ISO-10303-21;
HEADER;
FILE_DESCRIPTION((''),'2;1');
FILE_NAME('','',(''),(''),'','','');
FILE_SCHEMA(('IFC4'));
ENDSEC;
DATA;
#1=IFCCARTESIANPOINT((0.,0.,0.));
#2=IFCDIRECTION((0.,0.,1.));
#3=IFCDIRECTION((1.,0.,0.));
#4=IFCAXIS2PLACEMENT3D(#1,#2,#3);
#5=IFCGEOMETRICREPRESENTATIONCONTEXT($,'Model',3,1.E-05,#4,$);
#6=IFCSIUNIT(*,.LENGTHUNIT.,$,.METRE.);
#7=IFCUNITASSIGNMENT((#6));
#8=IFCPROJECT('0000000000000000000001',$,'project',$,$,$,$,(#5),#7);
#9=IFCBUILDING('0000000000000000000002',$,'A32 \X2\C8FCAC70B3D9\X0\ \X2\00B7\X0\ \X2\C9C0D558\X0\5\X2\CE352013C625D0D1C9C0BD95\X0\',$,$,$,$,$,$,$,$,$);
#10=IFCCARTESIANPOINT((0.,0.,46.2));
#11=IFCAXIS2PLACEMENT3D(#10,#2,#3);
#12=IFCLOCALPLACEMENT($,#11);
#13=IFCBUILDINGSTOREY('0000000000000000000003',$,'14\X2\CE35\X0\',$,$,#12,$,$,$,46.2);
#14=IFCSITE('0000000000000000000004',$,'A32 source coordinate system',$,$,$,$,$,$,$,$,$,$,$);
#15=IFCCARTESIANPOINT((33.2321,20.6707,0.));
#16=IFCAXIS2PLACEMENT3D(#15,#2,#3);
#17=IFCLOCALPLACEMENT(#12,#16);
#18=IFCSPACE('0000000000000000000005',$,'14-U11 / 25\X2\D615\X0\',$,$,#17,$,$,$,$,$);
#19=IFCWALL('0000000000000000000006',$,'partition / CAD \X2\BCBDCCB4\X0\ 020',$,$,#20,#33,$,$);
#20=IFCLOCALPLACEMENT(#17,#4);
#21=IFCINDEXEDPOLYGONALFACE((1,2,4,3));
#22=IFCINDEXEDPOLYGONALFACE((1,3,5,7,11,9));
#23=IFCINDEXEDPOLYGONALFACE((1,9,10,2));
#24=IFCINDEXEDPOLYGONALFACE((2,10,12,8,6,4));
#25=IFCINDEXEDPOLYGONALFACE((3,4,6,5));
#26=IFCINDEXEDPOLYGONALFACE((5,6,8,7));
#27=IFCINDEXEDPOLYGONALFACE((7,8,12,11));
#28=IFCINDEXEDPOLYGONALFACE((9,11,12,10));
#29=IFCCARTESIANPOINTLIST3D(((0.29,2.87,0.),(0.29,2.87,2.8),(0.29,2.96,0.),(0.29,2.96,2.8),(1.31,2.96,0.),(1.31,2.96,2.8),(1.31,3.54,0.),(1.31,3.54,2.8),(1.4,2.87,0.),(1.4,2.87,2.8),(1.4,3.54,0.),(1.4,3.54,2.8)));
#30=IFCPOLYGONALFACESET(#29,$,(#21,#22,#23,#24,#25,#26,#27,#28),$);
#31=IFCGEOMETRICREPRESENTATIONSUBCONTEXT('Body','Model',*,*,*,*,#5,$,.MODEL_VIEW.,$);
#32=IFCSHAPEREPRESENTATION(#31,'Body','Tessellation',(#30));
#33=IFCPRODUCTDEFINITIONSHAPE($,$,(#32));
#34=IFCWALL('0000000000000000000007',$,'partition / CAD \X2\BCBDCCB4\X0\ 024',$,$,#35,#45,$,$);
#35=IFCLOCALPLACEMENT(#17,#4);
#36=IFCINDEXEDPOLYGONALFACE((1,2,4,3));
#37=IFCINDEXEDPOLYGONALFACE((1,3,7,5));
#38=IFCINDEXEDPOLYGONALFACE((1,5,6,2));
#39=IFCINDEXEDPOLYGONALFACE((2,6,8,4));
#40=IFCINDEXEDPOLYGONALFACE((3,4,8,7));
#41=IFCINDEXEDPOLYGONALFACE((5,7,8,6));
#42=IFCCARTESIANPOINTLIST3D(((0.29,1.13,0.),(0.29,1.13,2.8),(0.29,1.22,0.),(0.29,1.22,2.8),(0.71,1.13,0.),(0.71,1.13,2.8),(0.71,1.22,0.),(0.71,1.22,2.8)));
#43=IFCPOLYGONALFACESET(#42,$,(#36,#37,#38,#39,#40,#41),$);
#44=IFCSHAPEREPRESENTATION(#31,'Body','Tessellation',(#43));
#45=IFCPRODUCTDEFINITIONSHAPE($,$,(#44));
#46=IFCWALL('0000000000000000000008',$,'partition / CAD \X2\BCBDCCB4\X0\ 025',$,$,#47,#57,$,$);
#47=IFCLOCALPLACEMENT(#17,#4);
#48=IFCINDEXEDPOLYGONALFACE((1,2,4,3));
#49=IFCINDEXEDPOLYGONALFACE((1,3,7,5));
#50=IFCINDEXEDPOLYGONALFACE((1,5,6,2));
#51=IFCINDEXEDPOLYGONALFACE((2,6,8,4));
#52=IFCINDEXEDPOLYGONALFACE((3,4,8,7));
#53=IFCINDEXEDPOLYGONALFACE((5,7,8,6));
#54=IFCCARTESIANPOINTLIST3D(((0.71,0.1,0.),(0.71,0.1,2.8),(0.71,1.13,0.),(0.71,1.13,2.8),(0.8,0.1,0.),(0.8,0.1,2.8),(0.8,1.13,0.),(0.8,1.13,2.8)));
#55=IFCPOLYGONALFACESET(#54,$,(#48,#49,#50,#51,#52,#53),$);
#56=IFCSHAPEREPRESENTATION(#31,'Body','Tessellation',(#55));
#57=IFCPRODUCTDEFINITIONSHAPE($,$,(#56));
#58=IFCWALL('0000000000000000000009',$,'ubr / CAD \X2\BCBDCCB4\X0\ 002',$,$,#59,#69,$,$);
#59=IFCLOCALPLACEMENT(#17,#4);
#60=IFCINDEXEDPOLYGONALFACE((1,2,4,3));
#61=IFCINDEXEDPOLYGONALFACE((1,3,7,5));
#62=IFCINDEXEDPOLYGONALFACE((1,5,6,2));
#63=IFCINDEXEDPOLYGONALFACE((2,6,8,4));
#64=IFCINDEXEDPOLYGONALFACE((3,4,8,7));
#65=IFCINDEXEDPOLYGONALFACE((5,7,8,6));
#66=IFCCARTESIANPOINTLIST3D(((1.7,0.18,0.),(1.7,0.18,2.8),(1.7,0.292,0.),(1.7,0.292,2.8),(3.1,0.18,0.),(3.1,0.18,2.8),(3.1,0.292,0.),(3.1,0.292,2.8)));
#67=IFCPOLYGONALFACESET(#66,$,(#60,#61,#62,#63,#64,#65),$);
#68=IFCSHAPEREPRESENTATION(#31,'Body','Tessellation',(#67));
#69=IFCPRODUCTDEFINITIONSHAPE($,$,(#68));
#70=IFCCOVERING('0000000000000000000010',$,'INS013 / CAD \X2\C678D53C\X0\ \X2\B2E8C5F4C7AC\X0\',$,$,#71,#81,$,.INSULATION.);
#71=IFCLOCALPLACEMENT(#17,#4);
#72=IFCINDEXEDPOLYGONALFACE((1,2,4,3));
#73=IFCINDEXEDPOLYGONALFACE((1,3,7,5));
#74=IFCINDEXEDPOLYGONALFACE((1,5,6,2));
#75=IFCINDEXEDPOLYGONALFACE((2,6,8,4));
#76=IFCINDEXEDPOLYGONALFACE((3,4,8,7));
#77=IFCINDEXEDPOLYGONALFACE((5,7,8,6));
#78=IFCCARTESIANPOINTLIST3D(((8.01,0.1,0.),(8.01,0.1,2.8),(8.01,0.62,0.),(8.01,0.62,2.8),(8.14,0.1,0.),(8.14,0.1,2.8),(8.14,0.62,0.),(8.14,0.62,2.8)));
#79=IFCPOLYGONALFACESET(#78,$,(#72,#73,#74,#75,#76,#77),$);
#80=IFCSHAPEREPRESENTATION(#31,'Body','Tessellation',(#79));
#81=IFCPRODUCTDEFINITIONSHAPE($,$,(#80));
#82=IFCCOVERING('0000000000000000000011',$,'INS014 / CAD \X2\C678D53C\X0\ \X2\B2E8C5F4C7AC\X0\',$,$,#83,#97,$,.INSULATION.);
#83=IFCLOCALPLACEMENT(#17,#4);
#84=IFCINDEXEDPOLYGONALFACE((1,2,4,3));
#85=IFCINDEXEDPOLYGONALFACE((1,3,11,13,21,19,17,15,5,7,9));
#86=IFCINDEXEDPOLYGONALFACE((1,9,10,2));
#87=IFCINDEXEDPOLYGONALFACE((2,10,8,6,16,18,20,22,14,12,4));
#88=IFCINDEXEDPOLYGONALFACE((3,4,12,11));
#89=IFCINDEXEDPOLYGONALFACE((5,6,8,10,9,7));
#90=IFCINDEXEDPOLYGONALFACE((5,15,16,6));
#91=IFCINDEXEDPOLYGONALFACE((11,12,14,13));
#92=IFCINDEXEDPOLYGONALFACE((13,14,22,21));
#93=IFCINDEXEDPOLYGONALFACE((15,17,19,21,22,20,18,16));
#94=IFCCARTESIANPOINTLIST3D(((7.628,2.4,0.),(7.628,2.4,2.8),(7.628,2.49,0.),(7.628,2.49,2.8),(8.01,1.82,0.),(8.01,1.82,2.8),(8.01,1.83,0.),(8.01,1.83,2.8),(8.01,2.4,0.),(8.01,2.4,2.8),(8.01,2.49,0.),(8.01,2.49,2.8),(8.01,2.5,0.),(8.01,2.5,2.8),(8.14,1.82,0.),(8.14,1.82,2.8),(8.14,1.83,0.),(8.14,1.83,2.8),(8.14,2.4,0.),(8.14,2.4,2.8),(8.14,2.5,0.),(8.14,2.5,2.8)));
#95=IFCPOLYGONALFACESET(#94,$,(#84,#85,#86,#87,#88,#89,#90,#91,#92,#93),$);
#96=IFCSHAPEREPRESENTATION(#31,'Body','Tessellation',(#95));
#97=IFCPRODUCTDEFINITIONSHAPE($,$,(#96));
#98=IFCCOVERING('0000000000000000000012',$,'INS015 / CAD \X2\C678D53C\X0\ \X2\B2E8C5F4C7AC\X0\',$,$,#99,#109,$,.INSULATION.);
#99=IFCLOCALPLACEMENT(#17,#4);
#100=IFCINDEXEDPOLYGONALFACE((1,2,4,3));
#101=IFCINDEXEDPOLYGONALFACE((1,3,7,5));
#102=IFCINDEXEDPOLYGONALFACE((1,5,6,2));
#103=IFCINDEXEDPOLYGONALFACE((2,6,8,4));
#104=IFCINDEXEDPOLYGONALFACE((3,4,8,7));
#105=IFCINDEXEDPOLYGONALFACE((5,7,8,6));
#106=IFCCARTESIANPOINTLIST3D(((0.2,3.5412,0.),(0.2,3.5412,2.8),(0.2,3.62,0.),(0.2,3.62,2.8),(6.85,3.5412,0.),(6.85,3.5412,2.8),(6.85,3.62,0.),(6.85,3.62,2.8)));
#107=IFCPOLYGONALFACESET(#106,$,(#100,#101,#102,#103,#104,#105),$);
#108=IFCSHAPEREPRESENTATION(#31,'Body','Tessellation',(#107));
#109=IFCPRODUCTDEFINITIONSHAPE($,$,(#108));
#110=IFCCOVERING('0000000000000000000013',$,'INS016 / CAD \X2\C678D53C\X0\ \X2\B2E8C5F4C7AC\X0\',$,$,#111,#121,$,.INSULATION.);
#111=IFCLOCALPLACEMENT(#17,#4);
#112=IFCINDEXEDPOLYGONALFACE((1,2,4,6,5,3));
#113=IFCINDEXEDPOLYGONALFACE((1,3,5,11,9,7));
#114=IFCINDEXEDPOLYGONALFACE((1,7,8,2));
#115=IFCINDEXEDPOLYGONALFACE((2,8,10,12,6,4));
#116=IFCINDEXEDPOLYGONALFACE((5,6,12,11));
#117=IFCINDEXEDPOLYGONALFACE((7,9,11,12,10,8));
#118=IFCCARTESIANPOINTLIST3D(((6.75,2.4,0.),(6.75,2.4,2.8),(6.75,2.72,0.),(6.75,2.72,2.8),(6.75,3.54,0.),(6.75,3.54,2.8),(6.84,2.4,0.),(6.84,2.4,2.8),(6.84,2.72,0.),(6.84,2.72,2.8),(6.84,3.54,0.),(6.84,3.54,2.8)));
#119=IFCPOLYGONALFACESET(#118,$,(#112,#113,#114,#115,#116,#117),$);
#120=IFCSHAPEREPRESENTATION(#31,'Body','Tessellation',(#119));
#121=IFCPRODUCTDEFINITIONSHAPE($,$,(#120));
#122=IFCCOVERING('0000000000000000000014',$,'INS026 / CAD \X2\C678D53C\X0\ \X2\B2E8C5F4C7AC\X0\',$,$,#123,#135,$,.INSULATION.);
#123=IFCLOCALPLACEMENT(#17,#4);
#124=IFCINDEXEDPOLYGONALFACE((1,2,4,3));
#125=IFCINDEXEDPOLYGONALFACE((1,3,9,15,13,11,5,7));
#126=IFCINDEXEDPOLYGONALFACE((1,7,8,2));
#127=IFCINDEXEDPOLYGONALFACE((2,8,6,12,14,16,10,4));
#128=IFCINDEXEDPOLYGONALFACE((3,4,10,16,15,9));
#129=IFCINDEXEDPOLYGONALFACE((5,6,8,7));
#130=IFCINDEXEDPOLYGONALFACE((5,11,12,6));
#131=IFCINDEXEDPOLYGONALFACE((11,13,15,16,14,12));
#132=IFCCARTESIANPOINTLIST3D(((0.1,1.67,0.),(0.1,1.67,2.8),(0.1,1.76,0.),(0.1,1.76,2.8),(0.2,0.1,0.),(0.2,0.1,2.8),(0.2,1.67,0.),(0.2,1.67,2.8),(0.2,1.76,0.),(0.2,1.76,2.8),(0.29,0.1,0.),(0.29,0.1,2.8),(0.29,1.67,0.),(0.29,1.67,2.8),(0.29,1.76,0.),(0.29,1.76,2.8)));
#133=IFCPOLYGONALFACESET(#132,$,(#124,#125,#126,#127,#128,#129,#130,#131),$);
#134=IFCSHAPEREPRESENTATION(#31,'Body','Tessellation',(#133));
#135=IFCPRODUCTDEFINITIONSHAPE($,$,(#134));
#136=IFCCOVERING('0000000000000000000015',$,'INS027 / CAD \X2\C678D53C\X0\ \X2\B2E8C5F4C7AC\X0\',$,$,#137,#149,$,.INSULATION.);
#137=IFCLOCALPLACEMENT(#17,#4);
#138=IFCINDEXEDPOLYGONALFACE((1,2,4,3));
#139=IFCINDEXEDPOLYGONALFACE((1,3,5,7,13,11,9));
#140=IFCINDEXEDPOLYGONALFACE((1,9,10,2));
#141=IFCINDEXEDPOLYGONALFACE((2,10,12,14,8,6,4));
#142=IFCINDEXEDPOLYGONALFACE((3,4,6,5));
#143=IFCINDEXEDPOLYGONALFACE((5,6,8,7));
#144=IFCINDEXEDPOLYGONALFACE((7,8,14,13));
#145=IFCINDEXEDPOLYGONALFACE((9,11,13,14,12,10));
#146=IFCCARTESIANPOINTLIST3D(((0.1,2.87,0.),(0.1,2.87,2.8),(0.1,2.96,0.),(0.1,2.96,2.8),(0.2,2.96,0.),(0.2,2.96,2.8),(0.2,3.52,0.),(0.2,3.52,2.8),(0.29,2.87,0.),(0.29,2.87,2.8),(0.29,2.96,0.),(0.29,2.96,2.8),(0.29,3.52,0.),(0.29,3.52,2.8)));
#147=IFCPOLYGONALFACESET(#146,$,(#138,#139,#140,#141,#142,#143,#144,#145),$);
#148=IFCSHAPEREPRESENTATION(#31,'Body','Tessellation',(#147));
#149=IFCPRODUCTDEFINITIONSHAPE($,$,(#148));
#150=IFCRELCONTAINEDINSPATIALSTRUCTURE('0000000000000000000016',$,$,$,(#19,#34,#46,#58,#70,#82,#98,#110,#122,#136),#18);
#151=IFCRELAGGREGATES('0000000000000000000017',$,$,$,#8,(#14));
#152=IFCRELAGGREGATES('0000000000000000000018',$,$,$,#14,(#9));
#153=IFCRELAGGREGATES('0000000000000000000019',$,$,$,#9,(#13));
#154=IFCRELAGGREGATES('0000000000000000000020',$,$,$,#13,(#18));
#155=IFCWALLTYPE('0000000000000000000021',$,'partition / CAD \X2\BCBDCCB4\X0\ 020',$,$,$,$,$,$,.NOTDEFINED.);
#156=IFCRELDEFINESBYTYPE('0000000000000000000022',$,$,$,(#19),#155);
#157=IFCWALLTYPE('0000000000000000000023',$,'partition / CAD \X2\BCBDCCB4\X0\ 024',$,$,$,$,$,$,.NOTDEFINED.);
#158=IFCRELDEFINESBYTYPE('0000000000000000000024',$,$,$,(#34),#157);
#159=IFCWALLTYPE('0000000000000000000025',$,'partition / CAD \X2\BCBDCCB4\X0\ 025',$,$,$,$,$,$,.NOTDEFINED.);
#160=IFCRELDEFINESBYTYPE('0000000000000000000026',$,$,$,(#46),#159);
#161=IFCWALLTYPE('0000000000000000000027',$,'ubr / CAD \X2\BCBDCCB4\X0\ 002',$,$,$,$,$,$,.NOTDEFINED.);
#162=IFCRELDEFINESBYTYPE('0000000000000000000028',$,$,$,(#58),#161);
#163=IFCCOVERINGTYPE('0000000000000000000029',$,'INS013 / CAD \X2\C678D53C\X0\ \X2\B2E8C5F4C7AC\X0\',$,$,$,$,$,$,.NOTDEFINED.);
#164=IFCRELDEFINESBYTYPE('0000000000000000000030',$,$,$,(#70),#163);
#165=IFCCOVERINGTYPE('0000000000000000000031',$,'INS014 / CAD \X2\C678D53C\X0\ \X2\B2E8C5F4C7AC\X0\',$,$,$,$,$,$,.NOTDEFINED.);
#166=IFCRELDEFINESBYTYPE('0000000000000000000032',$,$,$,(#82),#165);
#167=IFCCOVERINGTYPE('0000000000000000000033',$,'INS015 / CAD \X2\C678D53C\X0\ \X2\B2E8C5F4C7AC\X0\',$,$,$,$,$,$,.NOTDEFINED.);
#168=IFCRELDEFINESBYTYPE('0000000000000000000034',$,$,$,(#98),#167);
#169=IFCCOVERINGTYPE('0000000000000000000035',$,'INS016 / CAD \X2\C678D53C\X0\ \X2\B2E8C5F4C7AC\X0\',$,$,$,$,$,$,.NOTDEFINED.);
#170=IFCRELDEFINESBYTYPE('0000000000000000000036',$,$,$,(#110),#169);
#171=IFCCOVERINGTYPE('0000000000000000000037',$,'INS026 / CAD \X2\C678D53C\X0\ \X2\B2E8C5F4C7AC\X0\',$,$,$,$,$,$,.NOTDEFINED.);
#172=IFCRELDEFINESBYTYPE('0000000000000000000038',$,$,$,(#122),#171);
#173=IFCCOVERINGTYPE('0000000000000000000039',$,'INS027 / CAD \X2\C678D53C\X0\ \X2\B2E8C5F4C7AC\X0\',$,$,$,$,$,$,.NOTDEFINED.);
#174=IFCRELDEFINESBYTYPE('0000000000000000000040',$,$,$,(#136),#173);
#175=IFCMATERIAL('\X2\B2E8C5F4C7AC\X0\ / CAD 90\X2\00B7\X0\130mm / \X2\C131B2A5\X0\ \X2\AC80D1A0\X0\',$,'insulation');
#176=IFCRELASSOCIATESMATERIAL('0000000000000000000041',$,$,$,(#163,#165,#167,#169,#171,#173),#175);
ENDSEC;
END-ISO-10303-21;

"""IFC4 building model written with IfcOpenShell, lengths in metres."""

from ifc_helpers import new_model, si_unit, frame, origin, origin_with_axes, place, context, subcontext, project, spatial, polyline, outline, extrude, source, transform, mapped, material, type_object, type_shapes, element, save


model = new_model("IFC4")

# Units and contexts
model_context = context("Model", 3, precision=1e-05, world=origin_with_axes())
body_context = subcontext(model_context, "Body", "Model", "MODEL_VIEW")
ifc_project = project(units=[si_unit("LENGTHUNIT", "METRE")], contexts=[model_context])

# Site, building, storey, space
storey_placement = place(None, frame((0.0, 0.0, 46.2), z_axis=(0.0, 0.0, 1.0), x_axis=(1.0, 0.0, 0.0)))
space_placement = place(storey_placement, frame((33.2321, 20.6707, 0.0), z_axis=(0.0, 0.0, 1.0), x_axis=(1.0, 0.0, 0.0)))
site = spatial("IfcSite", under=ifc_project, Name="A32 source coordinate system")
building = spatial("IfcBuilding", under=site, Name="A32 주거동 · 지하5층–옥탑지붕")
storey = spatial("IfcBuildingStorey", under=building, at=storey_placement, Name="14층", Elevation=46.2)
space = spatial("IfcSpace", under=storey, at=space_placement, Name="14-U11 / 25형")

# Walls
wall_type_1 = type_object("IfcWallType", Name="partition / CAD 벽체 020", PredefinedType="NOTDEFINED")
shared_shape_1 = source(origin(), body_context, "Body", "SweptSolid", [
    extrude(outline(polyline([(0.29, 2.87), (0.29, 2.96), (1.31, 2.96), (1.31, 3.54), (1.4, 3.54), (1.4, 2.87), (0.29, 2.87)])), origin(), (0.0, 0.0, 1.0), 2.8),
])
type_shapes(wall_type_1, [shared_shape_1])
wall_1_placement = place(space_placement, origin_with_axes())
element("IfcWall", 1, at=wall_1_placement, inside=space, type_object=wall_type_1, Name="partition / CAD 벽체 020", context=body_context, shape_type="MappedRepresentation", body=[
    mapped(shared_shape_1, transform((0.0, 0.0, 0.0), scale=1.0)),
])
wall_type_2 = type_object("IfcWallType", Name="partition / CAD 벽체 024", PredefinedType="NOTDEFINED")
shared_shape_2 = source(origin(), body_context, "Body", "SweptSolid", [
    extrude(outline(polyline([(0.71, 1.13), (0.29, 1.13), (0.29, 1.22), (0.71, 1.22), (0.71, 1.13)])), origin(), (0.0, 0.0, 1.0), 2.8),
])
type_shapes(wall_type_2, [shared_shape_2])
wall_2_placement = place(space_placement, origin_with_axes())
element("IfcWall", 2, at=wall_2_placement, inside=space, type_object=wall_type_2, Name="partition / CAD 벽체 024", context=body_context, shape_type="MappedRepresentation", body=[
    mapped(shared_shape_2, transform((0.0, 0.0, 0.0), scale=1.0)),
])
wall_type_3 = type_object("IfcWallType", Name="partition / CAD 벽체 025", PredefinedType="NOTDEFINED")
shared_shape_3 = source(origin(), body_context, "Body", "SweptSolid", [
    extrude(outline(polyline([(0.71, 1.13), (0.8, 1.13), (0.8, 0.1), (0.71, 0.1), (0.71, 1.13)])), origin(), (0.0, 0.0, 1.0), 2.8),
])
type_shapes(wall_type_3, [shared_shape_3])
wall_3_placement = place(space_placement, origin_with_axes())
element("IfcWall", 3, at=wall_3_placement, inside=space, type_object=wall_type_3, Name="partition / CAD 벽체 025", context=body_context, shape_type="MappedRepresentation", body=[
    mapped(shared_shape_3, transform((0.0, 0.0, 0.0), scale=1.0)),
])
wall_type_4 = type_object("IfcWallType", Name="ubr / CAD 벽체 002", PredefinedType="NOTDEFINED")
shared_shape_4 = source(origin(), body_context, "Body", "SweptSolid", [
    extrude(outline(polyline([(3.1, 0.292), (3.1, 0.18), (1.7, 0.18), (1.7, 0.292), (3.1, 0.292)])), origin(), (0.0, 0.0, 1.0), 2.8),
])
type_shapes(wall_type_4, [shared_shape_4])
wall_4_placement = place(space_placement, origin_with_axes())
element("IfcWall", 4, at=wall_4_placement, inside=space, type_object=wall_type_4, Name="ubr / CAD 벽체 002", context=body_context, shape_type="MappedRepresentation", body=[
    mapped(shared_shape_4, transform((0.0, 0.0, 0.0), scale=1.0)),
])

# Coverings
ifc_material = material(Name="단열재 / CAD 90·130mm / 성능 검토", Category="insulation")
covering_type_1 = type_object("IfcCoveringType", Name="INS013 / CAD 외피 단열재", PredefinedType="NOTDEFINED", material=ifc_material)
shared_shape_5 = source(origin(), body_context, "Body", "SweptSolid", [
    extrude(outline(polyline([(8.14, 0.1), (8.01, 0.1), (8.01, 0.62), (8.14, 0.62), (8.14, 0.1)])), origin(), (0.0, 0.0, 1.0), 2.8),
])
type_shapes(covering_type_1, [shared_shape_5])
covering_1_placement = place(space_placement, origin_with_axes())
element("IfcCovering", 5, at=covering_1_placement, inside=space, type_object=covering_type_1, Name="INS013 / CAD 외피 단열재", PredefinedType="INSULATION", context=body_context, shape_type="MappedRepresentation", body=[
    mapped(shared_shape_5, transform((0.0, 0.0, 0.0), scale=1.0)),
])
covering_type_2 = type_object("IfcCoveringType", Name="INS014 / CAD 외피 단열재", PredefinedType="NOTDEFINED", material=ifc_material)
shared_shape_6 = source(origin(), body_context, "Body", "SweptSolid", [
    extrude(outline(polyline([(8.14, 2.5), (8.14, 2.4), (8.14, 1.83), (8.14, 1.82), (8.01, 1.82), (8.01, 1.83), (8.01, 2.4), (7.628, 2.4), (7.628, 2.49), (8.01, 2.49), (8.01, 2.5), (8.14, 2.5)])), origin(), (0.0, 0.0, 1.0), 2.8),
])
type_shapes(covering_type_2, [shared_shape_6])
covering_2_placement = place(space_placement, origin_with_axes())
element("IfcCovering", 6, at=covering_2_placement, inside=space, type_object=covering_type_2, Name="INS014 / CAD 외피 단열재", PredefinedType="INSULATION", context=body_context, shape_type="MappedRepresentation", body=[
    mapped(shared_shape_6, transform((0.0, 0.0, 0.0), scale=1.0)),
])
covering_type_3 = type_object("IfcCoveringType", Name="INS015 / CAD 외피 단열재", PredefinedType="NOTDEFINED", material=ifc_material)
shared_shape_7 = source(origin(), body_context, "Body", "SweptSolid", [
    extrude(outline(polyline([(0.2, 3.5412), (0.2, 3.62), (6.85, 3.62), (6.85, 3.5412), (0.2, 3.5412)])), origin(), (0.0, 0.0, 1.0), 2.8),
])
type_shapes(covering_type_3, [shared_shape_7])
covering_3_placement = place(space_placement, origin_with_axes())
element("IfcCovering", 7, at=covering_3_placement, inside=space, type_object=covering_type_3, Name="INS015 / CAD 외피 단열재", PredefinedType="INSULATION", context=body_context, shape_type="MappedRepresentation", body=[
    mapped(shared_shape_7, transform((0.0, 0.0, 0.0), scale=1.0)),
])
covering_type_4 = type_object("IfcCoveringType", Name="INS016 / CAD 외피 단열재", PredefinedType="NOTDEFINED", material=ifc_material)
shared_shape_8 = source(origin(), body_context, "Body", "SweptSolid", [
    extrude(outline(polyline([(6.84, 2.72), (6.84, 2.4), (6.75, 2.4), (6.75, 2.72), (6.75, 3.54), (6.84, 3.54), (6.84, 2.72)])), origin(), (0.0, 0.0, 1.0), 2.8),
])
type_shapes(covering_type_4, [shared_shape_8])
covering_4_placement = place(space_placement, origin_with_axes())
element("IfcCovering", 8, at=covering_4_placement, inside=space, type_object=covering_type_4, Name="INS016 / CAD 외피 단열재", PredefinedType="INSULATION", context=body_context, shape_type="MappedRepresentation", body=[
    mapped(shared_shape_8, transform((0.0, 0.0, 0.0), scale=1.0)),
])
covering_type_5 = type_object("IfcCoveringType", Name="INS026 / CAD 외피 단열재", PredefinedType="NOTDEFINED", material=ifc_material)
shared_shape_9 = source(origin(), body_context, "Body", "SweptSolid", [
    extrude(outline(polyline([(0.2, 1.76), (0.29, 1.76), (0.29, 1.67), (0.29, 0.1), (0.2, 0.1), (0.2, 1.67), (0.1, 1.67), (0.1, 1.76), (0.2, 1.76)])), origin(), (0.0, 0.0, 1.0), 2.8),
])
type_shapes(covering_type_5, [shared_shape_9])
covering_5_placement = place(space_placement, origin_with_axes())
element("IfcCovering", 9, at=covering_5_placement, inside=space, type_object=covering_type_5, Name="INS026 / CAD 외피 단열재", PredefinedType="INSULATION", context=body_context, shape_type="MappedRepresentation", body=[
    mapped(shared_shape_9, transform((0.0, 0.0, 0.0), scale=1.0)),
])
covering_type_6 = type_object("IfcCoveringType", Name="INS027 / CAD 외피 단열재", PredefinedType="NOTDEFINED", material=ifc_material)
shared_shape_10 = source(origin(), body_context, "Body", "SweptSolid", [
    extrude(outline(polyline([(0.2, 3.52), (0.29, 3.52), (0.29, 2.96), (0.29, 2.87), (0.1, 2.87), (0.1, 2.96), (0.2, 2.96), (0.2, 3.52)])), origin(), (0.0, 0.0, 1.0), 2.8),
])
type_shapes(covering_type_6, [shared_shape_10])
covering_6_placement = place(space_placement, origin_with_axes())
element("IfcCovering", 10, at=covering_6_placement, inside=space, type_object=covering_type_6, Name="INS027 / CAD 외피 단열재", PredefinedType="INSULATION", context=body_context, shape_type="MappedRepresentation", body=[
    mapped(shared_shape_10, transform((0.0, 0.0, 0.0), scale=1.0)),
])

save(model, "model.ifc")
